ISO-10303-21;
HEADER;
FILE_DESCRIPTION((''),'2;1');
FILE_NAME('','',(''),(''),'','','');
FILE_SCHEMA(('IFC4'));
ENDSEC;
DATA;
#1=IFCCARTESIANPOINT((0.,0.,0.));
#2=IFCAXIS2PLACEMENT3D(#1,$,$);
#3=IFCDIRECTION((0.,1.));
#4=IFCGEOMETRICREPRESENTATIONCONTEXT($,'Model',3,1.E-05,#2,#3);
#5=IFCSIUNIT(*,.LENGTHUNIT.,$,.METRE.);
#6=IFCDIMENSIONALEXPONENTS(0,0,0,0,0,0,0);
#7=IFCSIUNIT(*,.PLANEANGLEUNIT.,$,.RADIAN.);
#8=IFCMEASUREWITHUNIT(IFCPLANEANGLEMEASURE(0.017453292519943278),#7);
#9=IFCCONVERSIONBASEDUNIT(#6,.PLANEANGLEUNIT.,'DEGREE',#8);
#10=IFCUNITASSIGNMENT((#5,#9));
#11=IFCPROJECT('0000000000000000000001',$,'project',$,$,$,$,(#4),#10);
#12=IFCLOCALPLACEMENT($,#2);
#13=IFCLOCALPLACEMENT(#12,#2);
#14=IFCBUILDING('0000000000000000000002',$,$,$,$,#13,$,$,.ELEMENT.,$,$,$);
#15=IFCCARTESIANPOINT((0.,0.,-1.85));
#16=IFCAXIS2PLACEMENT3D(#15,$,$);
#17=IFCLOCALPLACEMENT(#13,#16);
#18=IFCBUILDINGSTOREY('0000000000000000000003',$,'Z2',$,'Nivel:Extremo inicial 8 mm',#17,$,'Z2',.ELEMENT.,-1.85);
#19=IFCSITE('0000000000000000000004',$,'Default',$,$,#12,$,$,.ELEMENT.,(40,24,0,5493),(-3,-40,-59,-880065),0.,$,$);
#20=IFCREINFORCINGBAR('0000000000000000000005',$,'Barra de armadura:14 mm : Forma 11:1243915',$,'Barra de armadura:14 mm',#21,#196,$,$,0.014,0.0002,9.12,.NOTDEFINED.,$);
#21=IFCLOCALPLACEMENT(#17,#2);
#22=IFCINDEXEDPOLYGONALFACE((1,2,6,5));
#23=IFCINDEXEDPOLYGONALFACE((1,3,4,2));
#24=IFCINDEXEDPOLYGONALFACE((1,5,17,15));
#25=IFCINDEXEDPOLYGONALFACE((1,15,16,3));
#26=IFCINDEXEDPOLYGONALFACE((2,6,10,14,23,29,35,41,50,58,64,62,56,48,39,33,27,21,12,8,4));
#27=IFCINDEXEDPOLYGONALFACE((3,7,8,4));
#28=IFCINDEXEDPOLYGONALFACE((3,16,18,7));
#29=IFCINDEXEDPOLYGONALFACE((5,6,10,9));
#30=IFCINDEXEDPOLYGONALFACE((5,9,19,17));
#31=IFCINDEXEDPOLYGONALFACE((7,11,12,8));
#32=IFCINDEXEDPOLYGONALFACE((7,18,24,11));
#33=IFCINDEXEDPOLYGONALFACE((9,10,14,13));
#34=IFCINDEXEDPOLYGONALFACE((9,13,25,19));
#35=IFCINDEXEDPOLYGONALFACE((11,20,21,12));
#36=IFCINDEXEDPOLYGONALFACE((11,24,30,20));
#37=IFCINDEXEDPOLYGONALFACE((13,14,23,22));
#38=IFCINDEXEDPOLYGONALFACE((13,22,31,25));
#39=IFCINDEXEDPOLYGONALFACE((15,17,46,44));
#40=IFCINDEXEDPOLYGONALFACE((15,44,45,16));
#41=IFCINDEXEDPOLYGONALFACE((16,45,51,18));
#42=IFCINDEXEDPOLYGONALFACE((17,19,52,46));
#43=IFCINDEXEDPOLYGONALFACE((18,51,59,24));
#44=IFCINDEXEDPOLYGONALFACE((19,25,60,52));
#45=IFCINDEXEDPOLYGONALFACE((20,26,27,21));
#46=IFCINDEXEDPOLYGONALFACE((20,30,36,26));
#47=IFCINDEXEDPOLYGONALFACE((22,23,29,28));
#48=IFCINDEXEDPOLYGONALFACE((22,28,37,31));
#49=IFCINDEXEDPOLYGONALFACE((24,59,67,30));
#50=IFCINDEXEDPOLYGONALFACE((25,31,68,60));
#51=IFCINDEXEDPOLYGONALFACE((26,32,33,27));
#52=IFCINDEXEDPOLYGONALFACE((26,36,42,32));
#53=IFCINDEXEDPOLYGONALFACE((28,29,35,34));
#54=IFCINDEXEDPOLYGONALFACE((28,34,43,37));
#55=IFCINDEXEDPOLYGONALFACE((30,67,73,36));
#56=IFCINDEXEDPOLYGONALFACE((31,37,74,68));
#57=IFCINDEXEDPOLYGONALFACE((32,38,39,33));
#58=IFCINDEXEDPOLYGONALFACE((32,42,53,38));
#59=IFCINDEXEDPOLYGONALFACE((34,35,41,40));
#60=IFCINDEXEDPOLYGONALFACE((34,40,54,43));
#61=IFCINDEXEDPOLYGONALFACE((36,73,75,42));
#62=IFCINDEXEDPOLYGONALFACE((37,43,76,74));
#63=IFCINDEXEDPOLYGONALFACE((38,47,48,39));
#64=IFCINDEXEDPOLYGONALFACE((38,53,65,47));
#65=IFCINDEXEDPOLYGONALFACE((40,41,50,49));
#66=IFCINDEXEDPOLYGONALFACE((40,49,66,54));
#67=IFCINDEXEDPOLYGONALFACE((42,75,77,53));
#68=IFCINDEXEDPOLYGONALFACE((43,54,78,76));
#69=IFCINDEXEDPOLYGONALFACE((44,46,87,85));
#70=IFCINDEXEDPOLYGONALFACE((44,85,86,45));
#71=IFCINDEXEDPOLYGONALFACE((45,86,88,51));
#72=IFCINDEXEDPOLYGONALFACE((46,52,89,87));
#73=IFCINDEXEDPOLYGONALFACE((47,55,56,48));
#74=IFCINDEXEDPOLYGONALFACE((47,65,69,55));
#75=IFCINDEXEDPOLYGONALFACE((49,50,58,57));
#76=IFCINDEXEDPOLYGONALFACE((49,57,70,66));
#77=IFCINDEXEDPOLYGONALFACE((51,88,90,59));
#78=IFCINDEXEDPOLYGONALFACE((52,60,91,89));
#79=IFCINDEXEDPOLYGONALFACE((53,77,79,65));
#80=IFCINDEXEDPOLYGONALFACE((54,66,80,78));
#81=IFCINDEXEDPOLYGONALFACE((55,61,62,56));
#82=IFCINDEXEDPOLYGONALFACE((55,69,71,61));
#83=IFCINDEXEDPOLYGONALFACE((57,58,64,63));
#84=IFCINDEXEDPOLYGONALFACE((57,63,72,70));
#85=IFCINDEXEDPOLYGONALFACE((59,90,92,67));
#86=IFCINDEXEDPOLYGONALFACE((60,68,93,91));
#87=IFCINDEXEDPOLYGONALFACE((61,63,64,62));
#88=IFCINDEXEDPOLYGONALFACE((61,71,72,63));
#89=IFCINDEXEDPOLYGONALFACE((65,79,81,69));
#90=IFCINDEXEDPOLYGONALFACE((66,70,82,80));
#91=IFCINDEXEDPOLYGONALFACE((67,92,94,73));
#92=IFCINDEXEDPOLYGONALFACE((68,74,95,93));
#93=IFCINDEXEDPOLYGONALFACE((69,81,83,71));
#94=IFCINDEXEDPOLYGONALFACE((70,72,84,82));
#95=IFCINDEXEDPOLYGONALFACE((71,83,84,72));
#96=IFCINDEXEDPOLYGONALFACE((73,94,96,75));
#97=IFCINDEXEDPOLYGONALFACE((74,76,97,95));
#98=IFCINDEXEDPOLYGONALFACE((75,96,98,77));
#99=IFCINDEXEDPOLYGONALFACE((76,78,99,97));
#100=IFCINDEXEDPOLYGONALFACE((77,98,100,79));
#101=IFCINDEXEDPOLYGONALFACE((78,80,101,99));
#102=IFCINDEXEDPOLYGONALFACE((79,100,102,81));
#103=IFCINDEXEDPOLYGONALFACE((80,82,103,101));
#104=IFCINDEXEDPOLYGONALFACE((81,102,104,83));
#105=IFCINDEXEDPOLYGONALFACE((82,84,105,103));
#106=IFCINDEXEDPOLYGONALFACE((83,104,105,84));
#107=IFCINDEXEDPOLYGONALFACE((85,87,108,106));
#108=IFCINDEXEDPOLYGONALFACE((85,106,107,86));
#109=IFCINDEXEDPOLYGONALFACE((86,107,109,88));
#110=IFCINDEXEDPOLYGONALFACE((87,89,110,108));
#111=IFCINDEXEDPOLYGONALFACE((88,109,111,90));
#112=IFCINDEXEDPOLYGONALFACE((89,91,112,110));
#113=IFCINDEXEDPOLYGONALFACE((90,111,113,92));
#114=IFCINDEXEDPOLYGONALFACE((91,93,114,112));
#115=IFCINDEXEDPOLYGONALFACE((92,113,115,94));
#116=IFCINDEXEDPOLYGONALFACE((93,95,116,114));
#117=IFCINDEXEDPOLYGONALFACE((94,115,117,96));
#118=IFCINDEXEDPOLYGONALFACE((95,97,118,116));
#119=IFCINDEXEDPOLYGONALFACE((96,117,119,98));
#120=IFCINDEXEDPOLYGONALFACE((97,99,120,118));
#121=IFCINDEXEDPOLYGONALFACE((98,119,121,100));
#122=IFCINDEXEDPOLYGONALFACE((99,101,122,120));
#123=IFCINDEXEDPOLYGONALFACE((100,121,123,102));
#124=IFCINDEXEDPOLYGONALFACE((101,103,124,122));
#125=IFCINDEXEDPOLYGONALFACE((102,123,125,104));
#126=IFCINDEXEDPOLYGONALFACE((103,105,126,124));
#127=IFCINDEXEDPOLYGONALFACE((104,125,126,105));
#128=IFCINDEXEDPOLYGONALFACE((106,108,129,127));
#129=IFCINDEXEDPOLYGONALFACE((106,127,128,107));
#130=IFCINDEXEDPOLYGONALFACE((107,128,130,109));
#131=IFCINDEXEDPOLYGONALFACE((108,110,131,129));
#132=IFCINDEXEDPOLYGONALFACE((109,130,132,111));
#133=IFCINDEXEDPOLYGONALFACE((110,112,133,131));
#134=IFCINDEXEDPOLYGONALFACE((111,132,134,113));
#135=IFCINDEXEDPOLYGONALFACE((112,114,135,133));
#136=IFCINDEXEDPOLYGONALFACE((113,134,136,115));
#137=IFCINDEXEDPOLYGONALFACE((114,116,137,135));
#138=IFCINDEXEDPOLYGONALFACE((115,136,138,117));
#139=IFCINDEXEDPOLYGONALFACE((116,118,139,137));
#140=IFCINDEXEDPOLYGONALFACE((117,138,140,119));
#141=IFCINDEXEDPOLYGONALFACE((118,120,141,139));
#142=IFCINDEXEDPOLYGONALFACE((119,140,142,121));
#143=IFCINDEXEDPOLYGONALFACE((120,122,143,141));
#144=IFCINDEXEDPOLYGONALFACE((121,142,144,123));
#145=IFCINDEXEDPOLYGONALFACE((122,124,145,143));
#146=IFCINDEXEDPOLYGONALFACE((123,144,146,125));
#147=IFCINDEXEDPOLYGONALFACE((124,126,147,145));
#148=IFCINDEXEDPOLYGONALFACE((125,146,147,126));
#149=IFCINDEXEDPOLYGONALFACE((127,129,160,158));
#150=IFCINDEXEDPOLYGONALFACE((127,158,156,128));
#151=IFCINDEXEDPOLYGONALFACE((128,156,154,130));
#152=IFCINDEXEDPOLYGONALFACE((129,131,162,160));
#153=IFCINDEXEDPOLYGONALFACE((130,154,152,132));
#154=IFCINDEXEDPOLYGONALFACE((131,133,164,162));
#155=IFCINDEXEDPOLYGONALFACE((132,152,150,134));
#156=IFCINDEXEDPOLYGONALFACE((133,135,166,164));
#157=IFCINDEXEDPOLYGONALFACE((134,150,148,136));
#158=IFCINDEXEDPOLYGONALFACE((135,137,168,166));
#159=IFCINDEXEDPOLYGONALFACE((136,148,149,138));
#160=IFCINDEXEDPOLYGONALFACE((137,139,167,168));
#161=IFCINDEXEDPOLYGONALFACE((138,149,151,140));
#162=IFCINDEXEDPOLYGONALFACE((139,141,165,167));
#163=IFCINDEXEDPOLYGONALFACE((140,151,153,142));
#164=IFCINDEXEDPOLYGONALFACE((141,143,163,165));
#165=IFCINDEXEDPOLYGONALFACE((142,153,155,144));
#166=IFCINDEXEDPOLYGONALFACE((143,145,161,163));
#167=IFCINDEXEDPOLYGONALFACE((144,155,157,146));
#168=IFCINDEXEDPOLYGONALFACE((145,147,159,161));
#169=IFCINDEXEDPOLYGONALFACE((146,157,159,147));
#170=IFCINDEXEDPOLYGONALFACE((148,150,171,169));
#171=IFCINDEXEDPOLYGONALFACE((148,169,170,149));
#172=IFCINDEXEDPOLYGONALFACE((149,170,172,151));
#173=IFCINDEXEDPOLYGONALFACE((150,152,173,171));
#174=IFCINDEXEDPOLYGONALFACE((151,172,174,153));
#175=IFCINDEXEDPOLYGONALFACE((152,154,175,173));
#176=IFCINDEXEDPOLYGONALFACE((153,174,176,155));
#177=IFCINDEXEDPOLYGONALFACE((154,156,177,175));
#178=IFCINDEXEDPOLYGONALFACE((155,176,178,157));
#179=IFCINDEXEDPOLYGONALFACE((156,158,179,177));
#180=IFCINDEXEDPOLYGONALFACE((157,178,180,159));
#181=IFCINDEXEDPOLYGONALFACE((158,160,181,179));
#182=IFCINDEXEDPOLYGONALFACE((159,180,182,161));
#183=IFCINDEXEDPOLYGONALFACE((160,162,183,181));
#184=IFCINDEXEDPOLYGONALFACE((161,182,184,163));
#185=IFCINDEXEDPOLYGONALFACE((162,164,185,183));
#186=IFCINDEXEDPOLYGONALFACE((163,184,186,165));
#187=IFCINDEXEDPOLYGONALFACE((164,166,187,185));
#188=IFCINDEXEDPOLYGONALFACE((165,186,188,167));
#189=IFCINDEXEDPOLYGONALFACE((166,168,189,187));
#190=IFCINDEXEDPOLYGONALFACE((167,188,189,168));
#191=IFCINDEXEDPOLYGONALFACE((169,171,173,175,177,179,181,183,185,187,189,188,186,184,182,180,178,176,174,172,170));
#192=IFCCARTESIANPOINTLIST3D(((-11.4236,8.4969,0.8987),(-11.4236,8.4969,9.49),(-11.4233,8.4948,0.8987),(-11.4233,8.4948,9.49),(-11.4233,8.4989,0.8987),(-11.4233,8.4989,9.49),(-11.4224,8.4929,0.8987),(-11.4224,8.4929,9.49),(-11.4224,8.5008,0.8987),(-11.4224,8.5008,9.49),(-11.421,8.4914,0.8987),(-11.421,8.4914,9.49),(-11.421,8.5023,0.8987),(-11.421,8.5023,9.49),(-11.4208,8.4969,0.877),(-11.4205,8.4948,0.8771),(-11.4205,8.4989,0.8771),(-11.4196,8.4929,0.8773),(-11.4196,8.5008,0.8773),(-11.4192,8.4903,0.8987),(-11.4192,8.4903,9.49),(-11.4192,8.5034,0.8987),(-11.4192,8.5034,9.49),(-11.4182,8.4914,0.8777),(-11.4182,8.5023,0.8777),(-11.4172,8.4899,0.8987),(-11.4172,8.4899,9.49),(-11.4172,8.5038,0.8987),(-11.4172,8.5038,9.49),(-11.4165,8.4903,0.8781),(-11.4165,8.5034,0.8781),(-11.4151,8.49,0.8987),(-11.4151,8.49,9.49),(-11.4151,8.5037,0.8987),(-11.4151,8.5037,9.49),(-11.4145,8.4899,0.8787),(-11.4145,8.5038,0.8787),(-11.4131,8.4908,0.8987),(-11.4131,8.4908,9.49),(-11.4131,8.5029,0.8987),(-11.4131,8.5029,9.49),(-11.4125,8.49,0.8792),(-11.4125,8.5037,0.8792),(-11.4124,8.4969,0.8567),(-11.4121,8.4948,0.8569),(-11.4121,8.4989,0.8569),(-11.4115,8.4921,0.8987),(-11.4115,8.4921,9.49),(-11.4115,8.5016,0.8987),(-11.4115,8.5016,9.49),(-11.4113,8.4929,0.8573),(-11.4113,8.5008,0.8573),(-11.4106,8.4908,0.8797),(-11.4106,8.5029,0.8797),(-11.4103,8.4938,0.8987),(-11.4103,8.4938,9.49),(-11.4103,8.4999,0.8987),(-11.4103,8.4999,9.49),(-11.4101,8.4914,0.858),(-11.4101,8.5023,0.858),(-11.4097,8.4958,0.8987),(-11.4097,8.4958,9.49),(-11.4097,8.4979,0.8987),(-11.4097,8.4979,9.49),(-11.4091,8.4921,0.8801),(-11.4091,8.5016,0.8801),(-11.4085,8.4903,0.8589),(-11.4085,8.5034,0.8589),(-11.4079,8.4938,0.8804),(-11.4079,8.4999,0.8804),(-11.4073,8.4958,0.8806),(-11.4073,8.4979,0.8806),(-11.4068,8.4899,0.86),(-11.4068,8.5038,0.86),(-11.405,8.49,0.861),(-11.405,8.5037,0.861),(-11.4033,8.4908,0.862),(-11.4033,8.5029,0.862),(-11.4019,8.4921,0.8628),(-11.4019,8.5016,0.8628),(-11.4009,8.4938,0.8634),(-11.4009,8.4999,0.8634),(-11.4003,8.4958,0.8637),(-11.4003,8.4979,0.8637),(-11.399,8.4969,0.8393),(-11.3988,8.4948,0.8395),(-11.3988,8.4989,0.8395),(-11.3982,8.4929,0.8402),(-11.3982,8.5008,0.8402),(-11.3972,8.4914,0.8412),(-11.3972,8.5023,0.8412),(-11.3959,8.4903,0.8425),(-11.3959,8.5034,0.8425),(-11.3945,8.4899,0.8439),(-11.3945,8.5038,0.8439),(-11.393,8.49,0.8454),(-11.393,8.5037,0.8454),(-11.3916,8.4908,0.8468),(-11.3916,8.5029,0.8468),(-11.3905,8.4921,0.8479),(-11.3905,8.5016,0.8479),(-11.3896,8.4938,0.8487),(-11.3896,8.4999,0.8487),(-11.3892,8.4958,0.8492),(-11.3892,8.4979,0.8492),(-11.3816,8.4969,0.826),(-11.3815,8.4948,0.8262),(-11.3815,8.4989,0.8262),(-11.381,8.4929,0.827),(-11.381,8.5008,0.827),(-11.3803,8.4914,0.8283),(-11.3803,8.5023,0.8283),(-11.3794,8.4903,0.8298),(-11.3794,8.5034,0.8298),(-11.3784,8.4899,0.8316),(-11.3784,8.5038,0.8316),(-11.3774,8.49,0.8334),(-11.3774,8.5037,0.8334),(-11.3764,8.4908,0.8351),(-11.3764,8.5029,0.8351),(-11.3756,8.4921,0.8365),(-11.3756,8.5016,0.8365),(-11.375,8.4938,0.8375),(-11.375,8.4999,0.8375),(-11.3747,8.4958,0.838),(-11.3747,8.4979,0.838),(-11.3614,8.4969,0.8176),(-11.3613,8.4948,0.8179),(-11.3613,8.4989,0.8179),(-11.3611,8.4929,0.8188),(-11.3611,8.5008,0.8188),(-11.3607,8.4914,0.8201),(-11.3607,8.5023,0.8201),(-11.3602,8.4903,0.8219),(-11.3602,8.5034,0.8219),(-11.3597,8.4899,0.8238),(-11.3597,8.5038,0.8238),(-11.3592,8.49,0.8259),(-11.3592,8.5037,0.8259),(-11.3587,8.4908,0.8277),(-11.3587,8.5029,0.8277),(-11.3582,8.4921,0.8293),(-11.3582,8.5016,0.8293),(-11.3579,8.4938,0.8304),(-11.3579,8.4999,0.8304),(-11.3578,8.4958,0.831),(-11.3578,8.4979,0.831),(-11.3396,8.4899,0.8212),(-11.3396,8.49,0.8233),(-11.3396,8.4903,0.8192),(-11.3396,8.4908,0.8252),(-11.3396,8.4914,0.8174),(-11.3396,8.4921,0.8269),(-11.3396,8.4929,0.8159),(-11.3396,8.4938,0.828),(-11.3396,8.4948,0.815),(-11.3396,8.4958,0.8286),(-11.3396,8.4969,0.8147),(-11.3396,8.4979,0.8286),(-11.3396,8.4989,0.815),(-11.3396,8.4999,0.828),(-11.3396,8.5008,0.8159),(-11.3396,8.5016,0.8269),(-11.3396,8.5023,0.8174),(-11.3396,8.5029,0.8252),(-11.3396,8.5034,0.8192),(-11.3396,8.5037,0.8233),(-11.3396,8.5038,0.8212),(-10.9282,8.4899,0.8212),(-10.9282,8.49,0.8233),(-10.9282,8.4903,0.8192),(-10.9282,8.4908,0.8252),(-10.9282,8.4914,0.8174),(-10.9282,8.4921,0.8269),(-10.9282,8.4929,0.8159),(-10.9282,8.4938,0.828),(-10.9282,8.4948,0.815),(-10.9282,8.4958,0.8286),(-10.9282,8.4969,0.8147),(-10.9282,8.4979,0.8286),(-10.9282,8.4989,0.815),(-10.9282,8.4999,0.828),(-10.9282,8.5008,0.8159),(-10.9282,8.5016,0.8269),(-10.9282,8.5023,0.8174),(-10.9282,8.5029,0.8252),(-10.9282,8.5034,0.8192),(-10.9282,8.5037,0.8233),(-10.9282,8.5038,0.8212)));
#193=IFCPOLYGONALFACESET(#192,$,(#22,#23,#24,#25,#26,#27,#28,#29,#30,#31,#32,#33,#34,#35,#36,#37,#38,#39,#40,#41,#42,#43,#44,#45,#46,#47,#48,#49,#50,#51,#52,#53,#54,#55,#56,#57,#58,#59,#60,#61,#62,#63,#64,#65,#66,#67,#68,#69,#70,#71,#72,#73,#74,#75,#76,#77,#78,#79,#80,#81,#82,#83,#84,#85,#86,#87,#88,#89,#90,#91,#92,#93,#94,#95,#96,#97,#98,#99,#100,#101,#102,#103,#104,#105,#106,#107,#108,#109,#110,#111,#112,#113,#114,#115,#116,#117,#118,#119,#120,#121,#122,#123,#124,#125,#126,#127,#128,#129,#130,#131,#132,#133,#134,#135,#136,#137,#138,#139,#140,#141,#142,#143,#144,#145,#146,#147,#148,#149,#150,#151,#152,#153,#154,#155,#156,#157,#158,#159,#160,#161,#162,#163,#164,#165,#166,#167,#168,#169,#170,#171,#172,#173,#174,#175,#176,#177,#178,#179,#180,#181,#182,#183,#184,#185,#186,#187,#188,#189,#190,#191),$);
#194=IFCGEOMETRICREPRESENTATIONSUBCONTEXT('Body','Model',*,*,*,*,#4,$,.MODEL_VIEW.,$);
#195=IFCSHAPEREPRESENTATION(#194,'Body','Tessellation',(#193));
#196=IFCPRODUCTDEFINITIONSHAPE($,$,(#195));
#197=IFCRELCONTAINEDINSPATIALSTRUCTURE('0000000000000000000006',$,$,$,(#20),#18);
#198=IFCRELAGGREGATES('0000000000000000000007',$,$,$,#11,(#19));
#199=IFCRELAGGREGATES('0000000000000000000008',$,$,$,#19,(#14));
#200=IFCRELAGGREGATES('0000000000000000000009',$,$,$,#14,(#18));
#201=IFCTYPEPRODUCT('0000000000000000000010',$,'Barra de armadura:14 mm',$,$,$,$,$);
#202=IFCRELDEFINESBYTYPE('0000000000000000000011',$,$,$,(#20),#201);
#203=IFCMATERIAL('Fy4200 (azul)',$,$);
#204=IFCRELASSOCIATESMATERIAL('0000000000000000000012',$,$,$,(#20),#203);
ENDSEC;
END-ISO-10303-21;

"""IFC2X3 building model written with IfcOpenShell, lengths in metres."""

from ifc_helpers import new_model, entity, si_unit, converted_unit, direction, frame, origin, place, context, subcontext, project, spatial, material, type_object, element, save


model = new_model("IFC2X3")

# Units and contexts
model_context = context("Model", 3, precision=1e-05, world=origin(), true_north=direction((0.0, 1.0)))
body_context = subcontext(model_context, "Body", "Model", "MODEL_VIEW")
ifc_project = project(units=[si_unit("LENGTHUNIT", "METRE"), converted_unit("PLANEANGLEUNIT", "DEGREE", entity("IfcPlaneAngleMeasure", 0.017453292519943278), si_unit("PLANEANGLEUNIT", "RADIAN"), dimensions=[0, 0, 0, 0, 0, 0, 0])], contexts=[model_context])

# Site, building, storey
site_placement = place(None, origin())
site = spatial("IfcSite", under=ifc_project, at=site_placement, Name="Default", CompositionType="ELEMENT", RefLatitude=(40, 24, 0, 5493), RefLongitude=(-3, -40, -59, -880065), RefElevation=0.0)
building_placement = place(site_placement, origin())
building = spatial("IfcBuilding", under=site, at=building_placement, CompositionType="ELEMENT")
storey_placement = place(building_placement, frame((0.0, 0.0, -1.85)))
storey = spatial("IfcBuildingStorey", under=building, at=storey_placement, Name="Z2", ObjectType="Nivel:Extremo inicial 8 mm", LongName="Z2", CompositionType="ELEMENT", Elevation=-1.85)

# Reinforcing bar
ifc_material_1 = material(Name="Fy4200 (azul)")
type_product_1 = type_object("IfcTypeProduct", Name="Barra de armadura:14 mm")
reinforcing_bar_1_placement = place(storey_placement, origin())
element("IfcReinforcingBar", 1, at=reinforcing_bar_1_placement, inside=storey, type_object=type_product_1, material=ifc_material_1, Name="Barra de armadura:14 mm : Forma 11:1243915", ObjectType="Barra de armadura:14 mm", BarLength=9.12, BarRole="NOTDEFINED", CrossSectionArea=0.0002, NominalDiameter=0.014, context=body_context, shape_type="AdvancedSweptSolid", body=[
    entity("IfcSweptDiskSolid", entity("IfcCompositeCurve", [entity("IfcCompositeCurveSegment", "CONTINUOUS", True, entity("IfcPolyline", [entity("IfcCartesianPoint", [-11.4166, 8.4969, 9.49]), entity("IfcCartesianPoint", [-11.4166, 8.4969, 0.8987])])), entity("IfcCompositeCurveSegment", "CONTINUOUS", True, entity("IfcTrimmedCurve", entity("IfcCircle", entity("IfcAxis2Placement3D", entity("IfcCartesianPoint", [-11.3396, 8.4969, 0.8987]), entity("IfcDirection", [0.0, -1.0, 0.0]), entity("IfcDirection", [0.0, 0.0, -1.0])), 0.077), [entity("IfcParameterValue", 270.0)], [entity("IfcParameterValue", 360.0)], True, "PARAMETER")), entity("IfcCompositeCurveSegment", "CONTINUOUS", True, entity("IfcPolyline", [entity("IfcCartesianPoint", [-11.3396, 8.4969, 0.8217]), entity("IfcCartesianPoint", [-10.9282, 8.4969, 0.8217])]))], False), 0.007, None, 0.0, 92.0),
])

save(model, "model.ifc")
